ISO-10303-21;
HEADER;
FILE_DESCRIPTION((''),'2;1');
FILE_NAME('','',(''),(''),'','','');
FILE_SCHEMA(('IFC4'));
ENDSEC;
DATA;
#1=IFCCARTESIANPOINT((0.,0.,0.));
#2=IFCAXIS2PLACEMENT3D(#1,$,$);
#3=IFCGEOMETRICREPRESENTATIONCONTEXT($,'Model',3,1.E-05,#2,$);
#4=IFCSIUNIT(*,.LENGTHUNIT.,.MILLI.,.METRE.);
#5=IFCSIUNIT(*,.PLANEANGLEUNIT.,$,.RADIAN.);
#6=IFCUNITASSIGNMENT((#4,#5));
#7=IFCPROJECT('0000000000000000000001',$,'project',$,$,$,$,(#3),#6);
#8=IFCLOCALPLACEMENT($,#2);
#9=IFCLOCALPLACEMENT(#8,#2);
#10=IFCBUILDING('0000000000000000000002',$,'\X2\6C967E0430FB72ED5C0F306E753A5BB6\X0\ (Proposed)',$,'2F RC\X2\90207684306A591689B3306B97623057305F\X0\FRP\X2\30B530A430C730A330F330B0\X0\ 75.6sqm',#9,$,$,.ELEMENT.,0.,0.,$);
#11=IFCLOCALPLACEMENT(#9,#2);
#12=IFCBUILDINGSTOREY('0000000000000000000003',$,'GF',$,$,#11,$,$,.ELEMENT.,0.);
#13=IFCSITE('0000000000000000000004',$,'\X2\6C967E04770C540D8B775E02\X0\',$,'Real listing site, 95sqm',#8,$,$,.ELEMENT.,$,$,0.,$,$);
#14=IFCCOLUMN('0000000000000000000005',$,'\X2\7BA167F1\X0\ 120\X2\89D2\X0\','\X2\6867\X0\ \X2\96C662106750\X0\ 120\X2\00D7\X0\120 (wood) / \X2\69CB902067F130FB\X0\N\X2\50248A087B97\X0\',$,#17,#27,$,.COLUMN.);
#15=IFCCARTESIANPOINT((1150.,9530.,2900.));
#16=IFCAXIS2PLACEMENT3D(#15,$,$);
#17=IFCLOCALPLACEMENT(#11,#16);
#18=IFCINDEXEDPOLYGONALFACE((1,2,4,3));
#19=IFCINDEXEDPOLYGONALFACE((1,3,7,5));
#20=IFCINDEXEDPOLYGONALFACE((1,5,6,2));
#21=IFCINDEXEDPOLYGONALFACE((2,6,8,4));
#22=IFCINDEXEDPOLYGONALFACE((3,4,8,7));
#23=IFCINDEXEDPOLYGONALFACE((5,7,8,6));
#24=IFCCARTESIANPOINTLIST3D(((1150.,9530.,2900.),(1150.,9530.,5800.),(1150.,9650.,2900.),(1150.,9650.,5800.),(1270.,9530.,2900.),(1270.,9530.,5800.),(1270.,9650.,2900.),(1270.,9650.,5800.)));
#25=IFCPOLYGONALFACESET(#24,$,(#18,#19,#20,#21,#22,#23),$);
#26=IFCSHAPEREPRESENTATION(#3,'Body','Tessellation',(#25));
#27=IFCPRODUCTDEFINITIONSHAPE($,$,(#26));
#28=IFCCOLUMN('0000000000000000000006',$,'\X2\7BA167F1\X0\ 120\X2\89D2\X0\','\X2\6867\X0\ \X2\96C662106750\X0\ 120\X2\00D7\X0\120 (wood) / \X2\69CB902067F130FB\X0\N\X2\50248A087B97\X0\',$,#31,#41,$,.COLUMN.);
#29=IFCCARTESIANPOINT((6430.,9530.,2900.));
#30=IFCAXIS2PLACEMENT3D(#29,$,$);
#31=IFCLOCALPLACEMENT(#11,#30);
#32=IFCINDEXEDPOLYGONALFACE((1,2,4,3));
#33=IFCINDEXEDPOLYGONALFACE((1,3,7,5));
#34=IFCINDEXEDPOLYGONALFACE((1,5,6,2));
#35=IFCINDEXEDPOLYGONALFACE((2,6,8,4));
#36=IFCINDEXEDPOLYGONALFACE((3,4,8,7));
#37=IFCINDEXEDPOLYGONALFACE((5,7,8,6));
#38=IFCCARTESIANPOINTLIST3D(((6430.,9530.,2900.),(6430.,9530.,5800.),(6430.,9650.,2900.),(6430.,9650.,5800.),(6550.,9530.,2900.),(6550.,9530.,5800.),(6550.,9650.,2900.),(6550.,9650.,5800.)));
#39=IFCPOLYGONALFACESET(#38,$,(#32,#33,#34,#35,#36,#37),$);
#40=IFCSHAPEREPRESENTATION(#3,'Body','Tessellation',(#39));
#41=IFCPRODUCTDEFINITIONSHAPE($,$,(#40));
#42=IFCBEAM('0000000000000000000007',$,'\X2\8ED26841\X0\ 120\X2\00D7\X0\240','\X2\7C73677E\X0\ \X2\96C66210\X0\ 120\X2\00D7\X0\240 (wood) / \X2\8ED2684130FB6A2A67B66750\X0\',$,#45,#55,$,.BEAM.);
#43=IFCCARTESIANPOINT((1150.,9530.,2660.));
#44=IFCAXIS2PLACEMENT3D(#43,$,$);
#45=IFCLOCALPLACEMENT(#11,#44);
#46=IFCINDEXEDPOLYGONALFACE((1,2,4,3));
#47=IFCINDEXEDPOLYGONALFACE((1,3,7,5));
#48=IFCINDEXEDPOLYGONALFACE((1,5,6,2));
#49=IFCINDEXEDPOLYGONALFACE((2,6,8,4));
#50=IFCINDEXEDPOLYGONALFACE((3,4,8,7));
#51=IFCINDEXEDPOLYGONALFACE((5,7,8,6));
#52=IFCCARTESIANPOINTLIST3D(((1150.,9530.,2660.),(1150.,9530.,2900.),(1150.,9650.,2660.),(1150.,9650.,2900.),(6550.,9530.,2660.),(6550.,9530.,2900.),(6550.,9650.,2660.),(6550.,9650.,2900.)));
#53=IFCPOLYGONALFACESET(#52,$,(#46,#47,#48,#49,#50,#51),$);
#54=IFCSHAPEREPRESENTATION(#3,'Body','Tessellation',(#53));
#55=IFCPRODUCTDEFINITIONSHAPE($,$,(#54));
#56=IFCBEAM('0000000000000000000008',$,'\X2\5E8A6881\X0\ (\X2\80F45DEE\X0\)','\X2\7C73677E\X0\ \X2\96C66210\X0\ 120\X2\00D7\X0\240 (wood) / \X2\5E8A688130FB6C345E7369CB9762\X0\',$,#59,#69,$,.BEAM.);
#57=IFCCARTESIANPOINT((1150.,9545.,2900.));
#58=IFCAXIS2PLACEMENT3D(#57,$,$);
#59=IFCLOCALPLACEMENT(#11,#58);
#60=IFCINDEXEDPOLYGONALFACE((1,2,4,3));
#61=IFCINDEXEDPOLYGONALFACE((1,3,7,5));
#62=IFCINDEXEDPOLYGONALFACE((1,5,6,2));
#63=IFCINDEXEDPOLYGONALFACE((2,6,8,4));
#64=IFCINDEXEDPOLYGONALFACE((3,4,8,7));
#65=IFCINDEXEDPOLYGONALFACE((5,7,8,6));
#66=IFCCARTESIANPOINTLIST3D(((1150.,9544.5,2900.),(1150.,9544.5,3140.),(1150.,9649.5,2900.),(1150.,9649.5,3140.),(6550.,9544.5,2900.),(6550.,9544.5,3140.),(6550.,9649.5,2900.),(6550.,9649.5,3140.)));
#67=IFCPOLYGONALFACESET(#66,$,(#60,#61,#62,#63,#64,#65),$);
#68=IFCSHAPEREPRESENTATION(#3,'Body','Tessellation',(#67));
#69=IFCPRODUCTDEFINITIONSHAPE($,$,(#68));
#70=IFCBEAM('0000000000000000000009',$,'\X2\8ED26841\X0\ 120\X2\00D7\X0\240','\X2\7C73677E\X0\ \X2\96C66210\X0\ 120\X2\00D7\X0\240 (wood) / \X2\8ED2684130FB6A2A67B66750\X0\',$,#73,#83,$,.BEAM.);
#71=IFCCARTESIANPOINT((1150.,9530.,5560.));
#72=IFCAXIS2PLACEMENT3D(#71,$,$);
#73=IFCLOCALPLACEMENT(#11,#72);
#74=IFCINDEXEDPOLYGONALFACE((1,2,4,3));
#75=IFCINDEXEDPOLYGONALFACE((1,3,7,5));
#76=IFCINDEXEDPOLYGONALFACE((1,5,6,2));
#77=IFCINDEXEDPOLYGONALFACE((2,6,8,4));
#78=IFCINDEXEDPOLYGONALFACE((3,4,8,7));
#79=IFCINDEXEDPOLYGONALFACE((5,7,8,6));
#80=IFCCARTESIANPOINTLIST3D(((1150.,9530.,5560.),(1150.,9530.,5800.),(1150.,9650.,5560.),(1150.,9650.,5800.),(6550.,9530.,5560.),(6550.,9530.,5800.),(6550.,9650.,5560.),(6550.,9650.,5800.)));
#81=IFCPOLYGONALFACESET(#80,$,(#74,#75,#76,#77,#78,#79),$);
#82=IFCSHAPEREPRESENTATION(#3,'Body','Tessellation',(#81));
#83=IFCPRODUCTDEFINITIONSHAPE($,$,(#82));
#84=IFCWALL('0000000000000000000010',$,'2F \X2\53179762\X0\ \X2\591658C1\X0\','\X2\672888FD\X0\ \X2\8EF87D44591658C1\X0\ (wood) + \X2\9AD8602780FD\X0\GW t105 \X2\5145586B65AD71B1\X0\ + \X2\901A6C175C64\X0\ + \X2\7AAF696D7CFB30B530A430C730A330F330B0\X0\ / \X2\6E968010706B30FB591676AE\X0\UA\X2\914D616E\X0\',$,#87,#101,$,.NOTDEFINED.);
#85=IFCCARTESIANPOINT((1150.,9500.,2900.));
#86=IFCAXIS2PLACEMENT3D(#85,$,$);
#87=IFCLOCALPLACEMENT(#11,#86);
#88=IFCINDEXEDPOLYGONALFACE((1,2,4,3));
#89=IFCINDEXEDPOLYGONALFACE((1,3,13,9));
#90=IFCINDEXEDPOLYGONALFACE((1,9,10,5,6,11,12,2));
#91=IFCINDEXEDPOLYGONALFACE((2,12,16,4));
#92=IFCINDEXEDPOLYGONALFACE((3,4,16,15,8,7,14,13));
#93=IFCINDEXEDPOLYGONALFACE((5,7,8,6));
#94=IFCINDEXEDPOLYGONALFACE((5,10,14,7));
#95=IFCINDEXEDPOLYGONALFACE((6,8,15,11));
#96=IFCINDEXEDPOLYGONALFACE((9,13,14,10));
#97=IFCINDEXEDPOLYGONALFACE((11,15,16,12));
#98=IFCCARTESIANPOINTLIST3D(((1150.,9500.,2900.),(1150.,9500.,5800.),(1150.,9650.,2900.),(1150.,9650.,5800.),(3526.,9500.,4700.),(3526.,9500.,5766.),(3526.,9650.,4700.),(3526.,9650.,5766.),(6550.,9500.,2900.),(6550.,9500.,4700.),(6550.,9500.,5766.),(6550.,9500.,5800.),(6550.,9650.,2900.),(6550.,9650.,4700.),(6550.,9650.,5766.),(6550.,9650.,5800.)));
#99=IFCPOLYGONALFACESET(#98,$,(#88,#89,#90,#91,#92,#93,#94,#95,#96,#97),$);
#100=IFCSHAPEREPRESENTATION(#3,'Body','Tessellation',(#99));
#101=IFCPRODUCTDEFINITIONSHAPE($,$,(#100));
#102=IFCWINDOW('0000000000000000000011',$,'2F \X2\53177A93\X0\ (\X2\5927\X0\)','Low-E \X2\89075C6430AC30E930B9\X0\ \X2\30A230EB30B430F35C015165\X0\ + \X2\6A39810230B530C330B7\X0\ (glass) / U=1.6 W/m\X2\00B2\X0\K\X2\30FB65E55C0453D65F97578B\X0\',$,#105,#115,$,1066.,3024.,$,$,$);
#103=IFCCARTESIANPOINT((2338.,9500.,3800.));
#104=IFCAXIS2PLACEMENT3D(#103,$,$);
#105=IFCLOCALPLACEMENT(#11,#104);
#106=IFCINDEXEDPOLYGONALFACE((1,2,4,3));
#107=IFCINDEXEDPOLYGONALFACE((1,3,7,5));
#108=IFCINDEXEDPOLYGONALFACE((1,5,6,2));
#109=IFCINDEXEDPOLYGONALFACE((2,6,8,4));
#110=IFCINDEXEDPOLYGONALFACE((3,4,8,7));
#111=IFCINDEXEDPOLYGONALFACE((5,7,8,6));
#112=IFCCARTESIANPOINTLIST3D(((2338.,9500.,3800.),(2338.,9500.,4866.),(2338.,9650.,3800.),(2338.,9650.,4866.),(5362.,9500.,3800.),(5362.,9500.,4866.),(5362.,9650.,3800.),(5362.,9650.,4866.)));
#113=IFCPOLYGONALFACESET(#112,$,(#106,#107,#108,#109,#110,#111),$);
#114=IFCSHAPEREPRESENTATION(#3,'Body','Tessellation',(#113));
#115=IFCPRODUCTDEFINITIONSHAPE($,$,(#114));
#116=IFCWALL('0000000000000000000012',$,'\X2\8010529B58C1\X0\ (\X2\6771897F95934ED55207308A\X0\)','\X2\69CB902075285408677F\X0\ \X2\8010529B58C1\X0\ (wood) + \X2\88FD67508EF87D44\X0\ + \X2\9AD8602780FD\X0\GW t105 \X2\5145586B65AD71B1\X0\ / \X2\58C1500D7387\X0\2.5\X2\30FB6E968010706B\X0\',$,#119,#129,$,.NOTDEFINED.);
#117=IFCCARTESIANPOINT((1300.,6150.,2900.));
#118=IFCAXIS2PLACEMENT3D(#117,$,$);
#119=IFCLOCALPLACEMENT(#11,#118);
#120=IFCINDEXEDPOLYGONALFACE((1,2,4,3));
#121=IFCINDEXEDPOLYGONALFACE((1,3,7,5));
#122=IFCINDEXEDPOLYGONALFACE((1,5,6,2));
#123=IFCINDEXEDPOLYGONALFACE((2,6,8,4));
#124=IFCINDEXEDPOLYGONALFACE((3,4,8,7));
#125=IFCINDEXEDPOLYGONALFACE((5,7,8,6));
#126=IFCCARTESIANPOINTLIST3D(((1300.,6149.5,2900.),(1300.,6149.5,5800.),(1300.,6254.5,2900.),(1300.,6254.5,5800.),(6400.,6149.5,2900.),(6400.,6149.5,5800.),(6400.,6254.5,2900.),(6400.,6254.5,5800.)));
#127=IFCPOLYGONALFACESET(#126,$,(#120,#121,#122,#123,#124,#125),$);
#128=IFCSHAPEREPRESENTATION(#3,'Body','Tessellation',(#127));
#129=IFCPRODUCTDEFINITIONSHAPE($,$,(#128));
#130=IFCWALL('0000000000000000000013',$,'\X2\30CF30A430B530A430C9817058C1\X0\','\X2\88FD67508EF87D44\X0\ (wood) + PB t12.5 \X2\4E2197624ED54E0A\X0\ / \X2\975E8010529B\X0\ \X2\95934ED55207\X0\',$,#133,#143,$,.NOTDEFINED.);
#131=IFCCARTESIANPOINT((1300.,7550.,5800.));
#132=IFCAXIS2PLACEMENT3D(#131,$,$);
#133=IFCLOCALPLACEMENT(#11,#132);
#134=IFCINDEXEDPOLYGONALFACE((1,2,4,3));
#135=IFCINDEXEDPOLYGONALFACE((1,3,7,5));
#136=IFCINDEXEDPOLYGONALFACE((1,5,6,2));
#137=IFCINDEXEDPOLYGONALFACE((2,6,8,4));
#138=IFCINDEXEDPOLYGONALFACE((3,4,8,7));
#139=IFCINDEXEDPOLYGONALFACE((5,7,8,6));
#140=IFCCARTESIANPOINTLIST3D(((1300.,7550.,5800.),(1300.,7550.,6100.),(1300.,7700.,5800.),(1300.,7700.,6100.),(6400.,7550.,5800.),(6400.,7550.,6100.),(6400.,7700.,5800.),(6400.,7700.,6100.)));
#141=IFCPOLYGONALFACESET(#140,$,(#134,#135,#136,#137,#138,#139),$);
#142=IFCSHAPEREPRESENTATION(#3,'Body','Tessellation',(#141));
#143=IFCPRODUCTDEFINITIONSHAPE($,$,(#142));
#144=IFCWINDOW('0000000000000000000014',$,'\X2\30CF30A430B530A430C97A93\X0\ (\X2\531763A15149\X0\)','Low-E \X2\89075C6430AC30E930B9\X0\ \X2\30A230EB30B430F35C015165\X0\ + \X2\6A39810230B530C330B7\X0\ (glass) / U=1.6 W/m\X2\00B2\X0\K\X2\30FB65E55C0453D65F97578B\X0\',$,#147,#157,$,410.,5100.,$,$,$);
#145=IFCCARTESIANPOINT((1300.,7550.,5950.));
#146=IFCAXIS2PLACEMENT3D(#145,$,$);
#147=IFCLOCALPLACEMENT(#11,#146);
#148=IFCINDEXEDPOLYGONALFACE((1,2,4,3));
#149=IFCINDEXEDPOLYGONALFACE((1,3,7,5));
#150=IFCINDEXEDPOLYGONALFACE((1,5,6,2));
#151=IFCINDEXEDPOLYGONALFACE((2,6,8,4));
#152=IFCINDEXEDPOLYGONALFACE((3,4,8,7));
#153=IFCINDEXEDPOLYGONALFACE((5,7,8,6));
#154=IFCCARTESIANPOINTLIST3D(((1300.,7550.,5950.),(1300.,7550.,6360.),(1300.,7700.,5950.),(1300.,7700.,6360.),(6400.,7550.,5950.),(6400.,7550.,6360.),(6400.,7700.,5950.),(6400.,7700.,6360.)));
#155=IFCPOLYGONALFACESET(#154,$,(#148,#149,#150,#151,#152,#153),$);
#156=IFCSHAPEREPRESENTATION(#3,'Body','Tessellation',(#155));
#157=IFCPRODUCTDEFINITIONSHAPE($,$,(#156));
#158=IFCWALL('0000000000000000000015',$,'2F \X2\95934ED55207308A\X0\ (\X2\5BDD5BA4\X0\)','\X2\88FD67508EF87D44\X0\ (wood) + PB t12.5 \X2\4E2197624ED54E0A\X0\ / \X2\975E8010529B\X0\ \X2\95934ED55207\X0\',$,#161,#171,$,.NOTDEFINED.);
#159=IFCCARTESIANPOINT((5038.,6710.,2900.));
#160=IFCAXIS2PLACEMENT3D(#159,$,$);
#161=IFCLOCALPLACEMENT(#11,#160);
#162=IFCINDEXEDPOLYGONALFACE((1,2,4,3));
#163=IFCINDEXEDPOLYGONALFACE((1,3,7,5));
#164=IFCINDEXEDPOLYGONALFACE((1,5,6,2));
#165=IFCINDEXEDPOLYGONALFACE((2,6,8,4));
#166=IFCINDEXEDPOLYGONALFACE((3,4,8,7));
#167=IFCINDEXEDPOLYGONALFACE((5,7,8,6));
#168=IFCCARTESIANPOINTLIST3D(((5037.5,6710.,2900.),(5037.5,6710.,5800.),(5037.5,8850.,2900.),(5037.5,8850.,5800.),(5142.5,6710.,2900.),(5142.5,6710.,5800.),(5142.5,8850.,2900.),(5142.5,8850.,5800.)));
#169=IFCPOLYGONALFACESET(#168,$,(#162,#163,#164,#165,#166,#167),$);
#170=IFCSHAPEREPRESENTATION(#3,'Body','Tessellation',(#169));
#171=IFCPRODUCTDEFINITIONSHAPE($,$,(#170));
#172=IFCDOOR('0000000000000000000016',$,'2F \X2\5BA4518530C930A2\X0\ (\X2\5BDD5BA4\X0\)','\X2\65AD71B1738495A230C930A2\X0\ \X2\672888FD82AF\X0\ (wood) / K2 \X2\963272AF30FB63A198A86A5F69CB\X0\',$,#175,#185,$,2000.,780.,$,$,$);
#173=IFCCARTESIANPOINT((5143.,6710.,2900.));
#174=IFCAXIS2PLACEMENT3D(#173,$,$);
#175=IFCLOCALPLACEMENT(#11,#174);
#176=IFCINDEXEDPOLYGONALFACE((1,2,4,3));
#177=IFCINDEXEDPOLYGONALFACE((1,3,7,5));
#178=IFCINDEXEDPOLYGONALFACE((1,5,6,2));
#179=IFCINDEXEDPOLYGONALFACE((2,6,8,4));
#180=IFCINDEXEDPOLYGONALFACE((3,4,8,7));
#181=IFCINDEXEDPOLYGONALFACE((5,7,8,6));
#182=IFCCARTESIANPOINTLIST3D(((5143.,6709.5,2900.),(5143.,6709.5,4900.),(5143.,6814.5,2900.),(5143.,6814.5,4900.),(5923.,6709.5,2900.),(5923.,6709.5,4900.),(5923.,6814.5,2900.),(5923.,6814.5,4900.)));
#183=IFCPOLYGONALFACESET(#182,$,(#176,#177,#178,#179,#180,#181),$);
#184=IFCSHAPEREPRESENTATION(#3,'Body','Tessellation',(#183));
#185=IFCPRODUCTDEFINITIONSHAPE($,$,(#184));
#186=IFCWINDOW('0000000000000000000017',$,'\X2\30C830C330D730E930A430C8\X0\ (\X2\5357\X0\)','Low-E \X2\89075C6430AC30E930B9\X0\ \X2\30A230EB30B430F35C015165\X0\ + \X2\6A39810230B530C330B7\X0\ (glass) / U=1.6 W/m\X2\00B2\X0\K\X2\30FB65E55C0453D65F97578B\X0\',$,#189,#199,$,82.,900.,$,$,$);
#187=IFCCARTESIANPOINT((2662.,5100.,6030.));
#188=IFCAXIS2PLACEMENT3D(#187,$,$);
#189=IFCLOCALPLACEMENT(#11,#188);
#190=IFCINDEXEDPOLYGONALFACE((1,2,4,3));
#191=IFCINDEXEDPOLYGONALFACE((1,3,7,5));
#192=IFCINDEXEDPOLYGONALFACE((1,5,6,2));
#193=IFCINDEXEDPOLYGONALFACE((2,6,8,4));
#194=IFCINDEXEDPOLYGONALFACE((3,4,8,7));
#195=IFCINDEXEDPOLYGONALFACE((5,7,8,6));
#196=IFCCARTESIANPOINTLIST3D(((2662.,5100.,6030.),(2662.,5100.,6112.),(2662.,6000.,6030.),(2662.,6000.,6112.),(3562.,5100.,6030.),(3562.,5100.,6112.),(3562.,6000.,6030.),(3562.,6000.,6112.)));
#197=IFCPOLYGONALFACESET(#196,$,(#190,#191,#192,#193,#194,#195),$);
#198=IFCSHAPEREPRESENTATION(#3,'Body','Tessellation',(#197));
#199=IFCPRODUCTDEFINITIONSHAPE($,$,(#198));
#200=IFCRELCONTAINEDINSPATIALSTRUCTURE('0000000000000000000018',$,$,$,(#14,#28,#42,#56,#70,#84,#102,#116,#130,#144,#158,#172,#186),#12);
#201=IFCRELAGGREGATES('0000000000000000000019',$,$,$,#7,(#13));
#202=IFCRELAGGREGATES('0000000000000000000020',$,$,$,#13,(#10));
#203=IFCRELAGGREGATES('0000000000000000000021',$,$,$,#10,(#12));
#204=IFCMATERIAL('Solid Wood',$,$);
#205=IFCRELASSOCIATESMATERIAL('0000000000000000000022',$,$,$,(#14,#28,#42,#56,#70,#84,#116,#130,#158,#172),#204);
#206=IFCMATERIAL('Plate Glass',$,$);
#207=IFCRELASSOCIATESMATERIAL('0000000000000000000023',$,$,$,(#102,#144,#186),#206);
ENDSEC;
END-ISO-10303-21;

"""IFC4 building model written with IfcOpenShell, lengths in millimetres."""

from ifc_helpers import new_model, si_unit, frame, frame_2d, origin, place, context, project, spatial, rectangle, extrude, material, element, fill, save


model = new_model("IFC4")

# Units and contexts
model_context = context("Model", 3, precision=1e-05, world=origin())
ifc_project = project(units=[si_unit("LENGTHUNIT", "METRE", prefix="MILLI"), si_unit("PLANEANGLEUNIT", "RADIAN")], contexts=[model_context])

# Site, building, storey
site_placement = place(None, origin())
site = spatial("IfcSite", under=ifc_project, at=site_placement, Name="沖縄県名護市", ObjectType="Real listing site, 95sqm", CompositionType="ELEMENT", RefElevation=0.0)
building_placement = place(site_placement, origin())
building = spatial("IfcBuilding", under=site, at=building_placement, Name="沖縄・狭小の町家 (Proposed)", ObjectType="2F RC造的な外観に面したFRPサイディング 75.6sqm", CompositionType="ELEMENT", ElevationOfRefHeight=0.0, ElevationOfTerrain=0.0)
storey_placement = place(building_placement, origin())
storey = spatial("IfcBuildingStorey", under=building, at=storey_placement, Name="GF", CompositionType="ELEMENT", Elevation=0.0)

# Columns
ifc_material_1 = material(Name="Solid Wood")
column_1_placement = place(storey_placement, frame((1150.0, 9530.0, 2900.0)))
element("IfcColumn", 1, at=column_1_placement, inside=storey, material=ifc_material_1, Name="管柱 120角", Description="桧 集成材 120×120 (wood) / 構造柱・N値計算", PredefinedType="COLUMN", context=model_context, shape_type="SweptSolid", body=[
    extrude(rectangle(XDim=120.0, YDim=120.0, at=frame_2d((60.0, 60.0))), frame((1150.0, 9530.0, 2900.0)), (0.0, 0.0, 1.0), 2900.0),
])
column_2_placement = place(storey_placement, frame((6430.0, 9530.0, 2900.0)))
element("IfcColumn", 2, at=column_2_placement, inside=storey, material=ifc_material_1, Name="管柱 120角", Description="桧 集成材 120×120 (wood) / 構造柱・N値計算", PredefinedType="COLUMN", context=model_context, shape_type="SweptSolid", body=[
    extrude(rectangle(XDim=120.0, YDim=120.0, at=frame_2d((60.0, 60.0))), frame((6430.0, 9530.0, 2900.0)), (0.0, 0.0, 1.0), 2900.0),
])

# Beams
beam_1_placement = place(storey_placement, frame((1150.0, 9530.0, 2660.0)))
element("IfcBeam", 3, at=beam_1_placement, inside=storey, material=ifc_material_1, Name="軒桁 120×240", Description="米松 集成 120×240 (wood) / 軒桁・横架材", PredefinedType="BEAM", context=model_context, shape_type="SweptSolid", body=[
    extrude(rectangle(XDim=5400.0, YDim=120.0, at=frame_2d((2700.0, 60.0))), frame((1150.0, 9530.0, 2660.0)), (0.0, 0.0, 1.0), 240.0),
])
beam_2_placement = place(storey_placement, frame((1150.0, 9545.0, 2900.0)))
element("IfcBeam", 4, at=beam_2_placement, inside=storey, material=ifc_material_1, Name="床梁 (胴差)", Description="米松 集成 120×240 (wood) / 床梁・水平構面", PredefinedType="BEAM", context=model_context, shape_type="SweptSolid", body=[
    extrude(rectangle(XDim=5400.0, YDim=105.0, at=frame_2d((2700.0, 52.0))), frame((1150.0, 9545.0, 2900.0)), (0.0, 0.0, 1.0), 240.0),
])
beam_3_placement = place(storey_placement, frame((1150.0, 9530.0, 5560.0)))
element("IfcBeam", 5, at=beam_3_placement, inside=storey, material=ifc_material_1, Name="軒桁 120×240", Description="米松 集成 120×240 (wood) / 軒桁・横架材", PredefinedType="BEAM", context=model_context, shape_type="SweptSolid", body=[
    extrude(rectangle(XDim=5400.0, YDim=120.0, at=frame_2d((2700.0, 60.0))), frame((1150.0, 9530.0, 5560.0)), (0.0, 0.0, 1.0), 240.0),
])

# Wall, opening, window
wall_1_placement = place(storey_placement, frame((1150.0, 9500.0, 2900.0)))
wall_1 = element("IfcWall", 6, at=wall_1_placement, inside=storey, material=ifc_material_1, Name="2F 北面 外壁", Description="木製 軸組外壁 (wood) + 高性能GW t105 充填断熱 + 通気層 + 窯業系サイディング / 準耐火・外皮UA配慮", PredefinedType="NOTDEFINED", context=model_context, shape_type="SweptSolid", body=[
    extrude(rectangle(XDim=5400.0, YDim=150.0, at=frame_2d((2700.0, 75.0))), frame((1150.0, 9500.0, 2900.0)), (0.0, 0.0, 1.0), 2900.0),
])
opening_1_placement = place(storey_placement, frame((2338.0, 9500.0, 3800.0)))
opening_1 = element("IfcOpeningElement", 7, at=opening_1_placement, cuts=wall_1, PredefinedType="NOTDEFINED", context=model_context, shape_type="SweptSolid", body=[
    extrude(rectangle(XDim=3024.0, YDim=150.0, at=frame_2d((1512.0, 75.0))), frame((2338.0, 9500.0, 3800.0)), (0.0, 0.0, 1.0), 1066.0),
])
ifc_material_2 = material(Name="Plate Glass")
window_1_placement = place(storey_placement, frame((2338.0, 9500.0, 3800.0)))
window_1 = element("IfcWindow", 8, at=window_1_placement, inside=storey, material=ifc_material_2, Name="2F 北窓 (大)", Description="Low-E 複層ガラス アルゴン封入 + 樹脂サッシ (glass) / U=1.6 W/m²K・日射取得型", OverallHeight=1066.0, OverallWidth=3024.0, context=model_context, shape_type="SweptSolid", body=[
    extrude(rectangle(XDim=3024.0, YDim=150.0, at=frame_2d((1512.0, 75.0))), frame((2338.0, 9500.0, 3800.0)), (0.0, 0.0, 1.0), 1066.0),
])
fill(opening_1, window_1)

# Wall
wall_2_placement = place(storey_placement, frame((1300.0, 6150.0, 2900.0)))
element("IfcWall", 9, at=wall_2_placement, inside=storey, material=ifc_material_1, Name="耐力壁 (東西間仕切り)", Description="構造用合板 耐力壁 (wood) + 製材軸組 + 高性能GW t105 充填断熱 / 壁倍率2.5・準耐火", PredefinedType="NOTDEFINED", context=model_context, shape_type="SweptSolid", body=[
    extrude(rectangle(XDim=5100.0, YDim=105.0, at=frame_2d((2550.0, 52.0))), frame((1300.0, 6150.0, 2900.0)), (0.0, 0.0, 1.0), 2900.0),
])

# Wall, opening, window
wall_3_placement = place(storey_placement, frame((1300.0, 7550.0, 5800.0)))
wall_3 = element("IfcWall", 10, at=wall_3_placement, inside=storey, material=ifc_material_1, Name="ハイサイド腰壁", Description="製材軸組 (wood) + PB t12.5 両面仕上 / 非耐力 間仕切", PredefinedType="NOTDEFINED", context=model_context, shape_type="SweptSolid", body=[
    extrude(rectangle(XDim=5100.0, YDim=150.0, at=frame_2d((2550.0, 75.0))), frame((1300.0, 7550.0, 5800.0)), (0.0, 0.0, 1.0), 700.0),
])
opening_2_placement = place(storey_placement, frame((1300.0, 7550.0, 5950.0)))
opening_2 = element("IfcOpeningElement", 11, at=opening_2_placement, cuts=wall_3, PredefinedType="NOTDEFINED", context=model_context, shape_type="SweptSolid", body=[
    extrude(rectangle(XDim=5100.0, YDim=150.0, at=frame_2d((2550.0, 75.0))), frame((1300.0, 7550.0, 5950.0)), (0.0, 0.0, 1.0), 410.0),
])
window_2_placement = place(storey_placement, frame((1300.0, 7550.0, 5950.0)))
window_2 = element("IfcWindow", 12, at=window_2_placement, inside=storey, material=ifc_material_2, Name="ハイサイド窓 (北採光)", Description="Low-E 複層ガラス アルゴン封入 + 樹脂サッシ (glass) / U=1.6 W/m²K・日射取得型", OverallHeight=410.0, OverallWidth=5100.0, context=model_context, shape_type="SweptSolid", body=[
    extrude(rectangle(XDim=5100.0, YDim=150.0, at=frame_2d((2550.0, 75.0))), frame((1300.0, 7550.0, 5950.0)), (0.0, 0.0, 1.0), 410.0),
])
fill(opening_2, window_2)

# Wall
wall_4_placement = place(storey_placement, frame((5038.0, 6710.0, 2900.0)))
element("IfcWall", 13, at=wall_4_placement, inside=storey, material=ifc_material_1, Name="2F 間仕切り (寝室)", Description="製材軸組 (wood) + PB t12.5 両面仕上 / 非耐力 間仕切", PredefinedType="NOTDEFINED", context=model_context, shape_type="SweptSolid", body=[
    extrude(rectangle(XDim=105.0, YDim=2140.0, at=frame_2d((52.0, 1070.0))), frame((5038.0, 6710.0, 2900.0)), (0.0, 0.0, 1.0), 2900.0),
])

# Door
door_placement = place(storey_placement, frame((5143.0, 6710.0, 2900.0)))
element("IfcDoor", 14, at=door_placement, inside=storey, material=ifc_material_1, Name="2F 室内ドア (寝室)", Description="断熱玄関ドア 木製芯 (wood) / K2 防犯・採風機構", OverallHeight=2000.0, OverallWidth=780.0, context=model_context, shape_type="SweptSolid", body=[
    extrude(rectangle(XDim=780.0, YDim=105.0, at=frame_2d((390.0, 52.0))), frame((5143.0, 6710.0, 2900.0)), (0.0, 0.0, 1.0), 2000.0),
])

# Window
window_3_placement = place(storey_placement, frame((2662.0, 5100.0, 6030.0)))
element("IfcWindow", 15, at=window_3_placement, inside=storey, material=ifc_material_2, Name="トップライト (南)", Description="Low-E 複層ガラス アルゴン封入 + 樹脂サッシ (glass) / U=1.6 W/m²K・日射取得型", OverallHeight=82.0, OverallWidth=900.0, context=model_context, shape_type="SweptSolid", body=[
    extrude(rectangle(XDim=900.0, YDim=900.0, at=frame_2d((450.0, 450.0))), frame((2662.0, 5100.0, 6030.0)), (0.0, 0.0, 1.0), 82.0),
])

save(model, "model.ifc")
